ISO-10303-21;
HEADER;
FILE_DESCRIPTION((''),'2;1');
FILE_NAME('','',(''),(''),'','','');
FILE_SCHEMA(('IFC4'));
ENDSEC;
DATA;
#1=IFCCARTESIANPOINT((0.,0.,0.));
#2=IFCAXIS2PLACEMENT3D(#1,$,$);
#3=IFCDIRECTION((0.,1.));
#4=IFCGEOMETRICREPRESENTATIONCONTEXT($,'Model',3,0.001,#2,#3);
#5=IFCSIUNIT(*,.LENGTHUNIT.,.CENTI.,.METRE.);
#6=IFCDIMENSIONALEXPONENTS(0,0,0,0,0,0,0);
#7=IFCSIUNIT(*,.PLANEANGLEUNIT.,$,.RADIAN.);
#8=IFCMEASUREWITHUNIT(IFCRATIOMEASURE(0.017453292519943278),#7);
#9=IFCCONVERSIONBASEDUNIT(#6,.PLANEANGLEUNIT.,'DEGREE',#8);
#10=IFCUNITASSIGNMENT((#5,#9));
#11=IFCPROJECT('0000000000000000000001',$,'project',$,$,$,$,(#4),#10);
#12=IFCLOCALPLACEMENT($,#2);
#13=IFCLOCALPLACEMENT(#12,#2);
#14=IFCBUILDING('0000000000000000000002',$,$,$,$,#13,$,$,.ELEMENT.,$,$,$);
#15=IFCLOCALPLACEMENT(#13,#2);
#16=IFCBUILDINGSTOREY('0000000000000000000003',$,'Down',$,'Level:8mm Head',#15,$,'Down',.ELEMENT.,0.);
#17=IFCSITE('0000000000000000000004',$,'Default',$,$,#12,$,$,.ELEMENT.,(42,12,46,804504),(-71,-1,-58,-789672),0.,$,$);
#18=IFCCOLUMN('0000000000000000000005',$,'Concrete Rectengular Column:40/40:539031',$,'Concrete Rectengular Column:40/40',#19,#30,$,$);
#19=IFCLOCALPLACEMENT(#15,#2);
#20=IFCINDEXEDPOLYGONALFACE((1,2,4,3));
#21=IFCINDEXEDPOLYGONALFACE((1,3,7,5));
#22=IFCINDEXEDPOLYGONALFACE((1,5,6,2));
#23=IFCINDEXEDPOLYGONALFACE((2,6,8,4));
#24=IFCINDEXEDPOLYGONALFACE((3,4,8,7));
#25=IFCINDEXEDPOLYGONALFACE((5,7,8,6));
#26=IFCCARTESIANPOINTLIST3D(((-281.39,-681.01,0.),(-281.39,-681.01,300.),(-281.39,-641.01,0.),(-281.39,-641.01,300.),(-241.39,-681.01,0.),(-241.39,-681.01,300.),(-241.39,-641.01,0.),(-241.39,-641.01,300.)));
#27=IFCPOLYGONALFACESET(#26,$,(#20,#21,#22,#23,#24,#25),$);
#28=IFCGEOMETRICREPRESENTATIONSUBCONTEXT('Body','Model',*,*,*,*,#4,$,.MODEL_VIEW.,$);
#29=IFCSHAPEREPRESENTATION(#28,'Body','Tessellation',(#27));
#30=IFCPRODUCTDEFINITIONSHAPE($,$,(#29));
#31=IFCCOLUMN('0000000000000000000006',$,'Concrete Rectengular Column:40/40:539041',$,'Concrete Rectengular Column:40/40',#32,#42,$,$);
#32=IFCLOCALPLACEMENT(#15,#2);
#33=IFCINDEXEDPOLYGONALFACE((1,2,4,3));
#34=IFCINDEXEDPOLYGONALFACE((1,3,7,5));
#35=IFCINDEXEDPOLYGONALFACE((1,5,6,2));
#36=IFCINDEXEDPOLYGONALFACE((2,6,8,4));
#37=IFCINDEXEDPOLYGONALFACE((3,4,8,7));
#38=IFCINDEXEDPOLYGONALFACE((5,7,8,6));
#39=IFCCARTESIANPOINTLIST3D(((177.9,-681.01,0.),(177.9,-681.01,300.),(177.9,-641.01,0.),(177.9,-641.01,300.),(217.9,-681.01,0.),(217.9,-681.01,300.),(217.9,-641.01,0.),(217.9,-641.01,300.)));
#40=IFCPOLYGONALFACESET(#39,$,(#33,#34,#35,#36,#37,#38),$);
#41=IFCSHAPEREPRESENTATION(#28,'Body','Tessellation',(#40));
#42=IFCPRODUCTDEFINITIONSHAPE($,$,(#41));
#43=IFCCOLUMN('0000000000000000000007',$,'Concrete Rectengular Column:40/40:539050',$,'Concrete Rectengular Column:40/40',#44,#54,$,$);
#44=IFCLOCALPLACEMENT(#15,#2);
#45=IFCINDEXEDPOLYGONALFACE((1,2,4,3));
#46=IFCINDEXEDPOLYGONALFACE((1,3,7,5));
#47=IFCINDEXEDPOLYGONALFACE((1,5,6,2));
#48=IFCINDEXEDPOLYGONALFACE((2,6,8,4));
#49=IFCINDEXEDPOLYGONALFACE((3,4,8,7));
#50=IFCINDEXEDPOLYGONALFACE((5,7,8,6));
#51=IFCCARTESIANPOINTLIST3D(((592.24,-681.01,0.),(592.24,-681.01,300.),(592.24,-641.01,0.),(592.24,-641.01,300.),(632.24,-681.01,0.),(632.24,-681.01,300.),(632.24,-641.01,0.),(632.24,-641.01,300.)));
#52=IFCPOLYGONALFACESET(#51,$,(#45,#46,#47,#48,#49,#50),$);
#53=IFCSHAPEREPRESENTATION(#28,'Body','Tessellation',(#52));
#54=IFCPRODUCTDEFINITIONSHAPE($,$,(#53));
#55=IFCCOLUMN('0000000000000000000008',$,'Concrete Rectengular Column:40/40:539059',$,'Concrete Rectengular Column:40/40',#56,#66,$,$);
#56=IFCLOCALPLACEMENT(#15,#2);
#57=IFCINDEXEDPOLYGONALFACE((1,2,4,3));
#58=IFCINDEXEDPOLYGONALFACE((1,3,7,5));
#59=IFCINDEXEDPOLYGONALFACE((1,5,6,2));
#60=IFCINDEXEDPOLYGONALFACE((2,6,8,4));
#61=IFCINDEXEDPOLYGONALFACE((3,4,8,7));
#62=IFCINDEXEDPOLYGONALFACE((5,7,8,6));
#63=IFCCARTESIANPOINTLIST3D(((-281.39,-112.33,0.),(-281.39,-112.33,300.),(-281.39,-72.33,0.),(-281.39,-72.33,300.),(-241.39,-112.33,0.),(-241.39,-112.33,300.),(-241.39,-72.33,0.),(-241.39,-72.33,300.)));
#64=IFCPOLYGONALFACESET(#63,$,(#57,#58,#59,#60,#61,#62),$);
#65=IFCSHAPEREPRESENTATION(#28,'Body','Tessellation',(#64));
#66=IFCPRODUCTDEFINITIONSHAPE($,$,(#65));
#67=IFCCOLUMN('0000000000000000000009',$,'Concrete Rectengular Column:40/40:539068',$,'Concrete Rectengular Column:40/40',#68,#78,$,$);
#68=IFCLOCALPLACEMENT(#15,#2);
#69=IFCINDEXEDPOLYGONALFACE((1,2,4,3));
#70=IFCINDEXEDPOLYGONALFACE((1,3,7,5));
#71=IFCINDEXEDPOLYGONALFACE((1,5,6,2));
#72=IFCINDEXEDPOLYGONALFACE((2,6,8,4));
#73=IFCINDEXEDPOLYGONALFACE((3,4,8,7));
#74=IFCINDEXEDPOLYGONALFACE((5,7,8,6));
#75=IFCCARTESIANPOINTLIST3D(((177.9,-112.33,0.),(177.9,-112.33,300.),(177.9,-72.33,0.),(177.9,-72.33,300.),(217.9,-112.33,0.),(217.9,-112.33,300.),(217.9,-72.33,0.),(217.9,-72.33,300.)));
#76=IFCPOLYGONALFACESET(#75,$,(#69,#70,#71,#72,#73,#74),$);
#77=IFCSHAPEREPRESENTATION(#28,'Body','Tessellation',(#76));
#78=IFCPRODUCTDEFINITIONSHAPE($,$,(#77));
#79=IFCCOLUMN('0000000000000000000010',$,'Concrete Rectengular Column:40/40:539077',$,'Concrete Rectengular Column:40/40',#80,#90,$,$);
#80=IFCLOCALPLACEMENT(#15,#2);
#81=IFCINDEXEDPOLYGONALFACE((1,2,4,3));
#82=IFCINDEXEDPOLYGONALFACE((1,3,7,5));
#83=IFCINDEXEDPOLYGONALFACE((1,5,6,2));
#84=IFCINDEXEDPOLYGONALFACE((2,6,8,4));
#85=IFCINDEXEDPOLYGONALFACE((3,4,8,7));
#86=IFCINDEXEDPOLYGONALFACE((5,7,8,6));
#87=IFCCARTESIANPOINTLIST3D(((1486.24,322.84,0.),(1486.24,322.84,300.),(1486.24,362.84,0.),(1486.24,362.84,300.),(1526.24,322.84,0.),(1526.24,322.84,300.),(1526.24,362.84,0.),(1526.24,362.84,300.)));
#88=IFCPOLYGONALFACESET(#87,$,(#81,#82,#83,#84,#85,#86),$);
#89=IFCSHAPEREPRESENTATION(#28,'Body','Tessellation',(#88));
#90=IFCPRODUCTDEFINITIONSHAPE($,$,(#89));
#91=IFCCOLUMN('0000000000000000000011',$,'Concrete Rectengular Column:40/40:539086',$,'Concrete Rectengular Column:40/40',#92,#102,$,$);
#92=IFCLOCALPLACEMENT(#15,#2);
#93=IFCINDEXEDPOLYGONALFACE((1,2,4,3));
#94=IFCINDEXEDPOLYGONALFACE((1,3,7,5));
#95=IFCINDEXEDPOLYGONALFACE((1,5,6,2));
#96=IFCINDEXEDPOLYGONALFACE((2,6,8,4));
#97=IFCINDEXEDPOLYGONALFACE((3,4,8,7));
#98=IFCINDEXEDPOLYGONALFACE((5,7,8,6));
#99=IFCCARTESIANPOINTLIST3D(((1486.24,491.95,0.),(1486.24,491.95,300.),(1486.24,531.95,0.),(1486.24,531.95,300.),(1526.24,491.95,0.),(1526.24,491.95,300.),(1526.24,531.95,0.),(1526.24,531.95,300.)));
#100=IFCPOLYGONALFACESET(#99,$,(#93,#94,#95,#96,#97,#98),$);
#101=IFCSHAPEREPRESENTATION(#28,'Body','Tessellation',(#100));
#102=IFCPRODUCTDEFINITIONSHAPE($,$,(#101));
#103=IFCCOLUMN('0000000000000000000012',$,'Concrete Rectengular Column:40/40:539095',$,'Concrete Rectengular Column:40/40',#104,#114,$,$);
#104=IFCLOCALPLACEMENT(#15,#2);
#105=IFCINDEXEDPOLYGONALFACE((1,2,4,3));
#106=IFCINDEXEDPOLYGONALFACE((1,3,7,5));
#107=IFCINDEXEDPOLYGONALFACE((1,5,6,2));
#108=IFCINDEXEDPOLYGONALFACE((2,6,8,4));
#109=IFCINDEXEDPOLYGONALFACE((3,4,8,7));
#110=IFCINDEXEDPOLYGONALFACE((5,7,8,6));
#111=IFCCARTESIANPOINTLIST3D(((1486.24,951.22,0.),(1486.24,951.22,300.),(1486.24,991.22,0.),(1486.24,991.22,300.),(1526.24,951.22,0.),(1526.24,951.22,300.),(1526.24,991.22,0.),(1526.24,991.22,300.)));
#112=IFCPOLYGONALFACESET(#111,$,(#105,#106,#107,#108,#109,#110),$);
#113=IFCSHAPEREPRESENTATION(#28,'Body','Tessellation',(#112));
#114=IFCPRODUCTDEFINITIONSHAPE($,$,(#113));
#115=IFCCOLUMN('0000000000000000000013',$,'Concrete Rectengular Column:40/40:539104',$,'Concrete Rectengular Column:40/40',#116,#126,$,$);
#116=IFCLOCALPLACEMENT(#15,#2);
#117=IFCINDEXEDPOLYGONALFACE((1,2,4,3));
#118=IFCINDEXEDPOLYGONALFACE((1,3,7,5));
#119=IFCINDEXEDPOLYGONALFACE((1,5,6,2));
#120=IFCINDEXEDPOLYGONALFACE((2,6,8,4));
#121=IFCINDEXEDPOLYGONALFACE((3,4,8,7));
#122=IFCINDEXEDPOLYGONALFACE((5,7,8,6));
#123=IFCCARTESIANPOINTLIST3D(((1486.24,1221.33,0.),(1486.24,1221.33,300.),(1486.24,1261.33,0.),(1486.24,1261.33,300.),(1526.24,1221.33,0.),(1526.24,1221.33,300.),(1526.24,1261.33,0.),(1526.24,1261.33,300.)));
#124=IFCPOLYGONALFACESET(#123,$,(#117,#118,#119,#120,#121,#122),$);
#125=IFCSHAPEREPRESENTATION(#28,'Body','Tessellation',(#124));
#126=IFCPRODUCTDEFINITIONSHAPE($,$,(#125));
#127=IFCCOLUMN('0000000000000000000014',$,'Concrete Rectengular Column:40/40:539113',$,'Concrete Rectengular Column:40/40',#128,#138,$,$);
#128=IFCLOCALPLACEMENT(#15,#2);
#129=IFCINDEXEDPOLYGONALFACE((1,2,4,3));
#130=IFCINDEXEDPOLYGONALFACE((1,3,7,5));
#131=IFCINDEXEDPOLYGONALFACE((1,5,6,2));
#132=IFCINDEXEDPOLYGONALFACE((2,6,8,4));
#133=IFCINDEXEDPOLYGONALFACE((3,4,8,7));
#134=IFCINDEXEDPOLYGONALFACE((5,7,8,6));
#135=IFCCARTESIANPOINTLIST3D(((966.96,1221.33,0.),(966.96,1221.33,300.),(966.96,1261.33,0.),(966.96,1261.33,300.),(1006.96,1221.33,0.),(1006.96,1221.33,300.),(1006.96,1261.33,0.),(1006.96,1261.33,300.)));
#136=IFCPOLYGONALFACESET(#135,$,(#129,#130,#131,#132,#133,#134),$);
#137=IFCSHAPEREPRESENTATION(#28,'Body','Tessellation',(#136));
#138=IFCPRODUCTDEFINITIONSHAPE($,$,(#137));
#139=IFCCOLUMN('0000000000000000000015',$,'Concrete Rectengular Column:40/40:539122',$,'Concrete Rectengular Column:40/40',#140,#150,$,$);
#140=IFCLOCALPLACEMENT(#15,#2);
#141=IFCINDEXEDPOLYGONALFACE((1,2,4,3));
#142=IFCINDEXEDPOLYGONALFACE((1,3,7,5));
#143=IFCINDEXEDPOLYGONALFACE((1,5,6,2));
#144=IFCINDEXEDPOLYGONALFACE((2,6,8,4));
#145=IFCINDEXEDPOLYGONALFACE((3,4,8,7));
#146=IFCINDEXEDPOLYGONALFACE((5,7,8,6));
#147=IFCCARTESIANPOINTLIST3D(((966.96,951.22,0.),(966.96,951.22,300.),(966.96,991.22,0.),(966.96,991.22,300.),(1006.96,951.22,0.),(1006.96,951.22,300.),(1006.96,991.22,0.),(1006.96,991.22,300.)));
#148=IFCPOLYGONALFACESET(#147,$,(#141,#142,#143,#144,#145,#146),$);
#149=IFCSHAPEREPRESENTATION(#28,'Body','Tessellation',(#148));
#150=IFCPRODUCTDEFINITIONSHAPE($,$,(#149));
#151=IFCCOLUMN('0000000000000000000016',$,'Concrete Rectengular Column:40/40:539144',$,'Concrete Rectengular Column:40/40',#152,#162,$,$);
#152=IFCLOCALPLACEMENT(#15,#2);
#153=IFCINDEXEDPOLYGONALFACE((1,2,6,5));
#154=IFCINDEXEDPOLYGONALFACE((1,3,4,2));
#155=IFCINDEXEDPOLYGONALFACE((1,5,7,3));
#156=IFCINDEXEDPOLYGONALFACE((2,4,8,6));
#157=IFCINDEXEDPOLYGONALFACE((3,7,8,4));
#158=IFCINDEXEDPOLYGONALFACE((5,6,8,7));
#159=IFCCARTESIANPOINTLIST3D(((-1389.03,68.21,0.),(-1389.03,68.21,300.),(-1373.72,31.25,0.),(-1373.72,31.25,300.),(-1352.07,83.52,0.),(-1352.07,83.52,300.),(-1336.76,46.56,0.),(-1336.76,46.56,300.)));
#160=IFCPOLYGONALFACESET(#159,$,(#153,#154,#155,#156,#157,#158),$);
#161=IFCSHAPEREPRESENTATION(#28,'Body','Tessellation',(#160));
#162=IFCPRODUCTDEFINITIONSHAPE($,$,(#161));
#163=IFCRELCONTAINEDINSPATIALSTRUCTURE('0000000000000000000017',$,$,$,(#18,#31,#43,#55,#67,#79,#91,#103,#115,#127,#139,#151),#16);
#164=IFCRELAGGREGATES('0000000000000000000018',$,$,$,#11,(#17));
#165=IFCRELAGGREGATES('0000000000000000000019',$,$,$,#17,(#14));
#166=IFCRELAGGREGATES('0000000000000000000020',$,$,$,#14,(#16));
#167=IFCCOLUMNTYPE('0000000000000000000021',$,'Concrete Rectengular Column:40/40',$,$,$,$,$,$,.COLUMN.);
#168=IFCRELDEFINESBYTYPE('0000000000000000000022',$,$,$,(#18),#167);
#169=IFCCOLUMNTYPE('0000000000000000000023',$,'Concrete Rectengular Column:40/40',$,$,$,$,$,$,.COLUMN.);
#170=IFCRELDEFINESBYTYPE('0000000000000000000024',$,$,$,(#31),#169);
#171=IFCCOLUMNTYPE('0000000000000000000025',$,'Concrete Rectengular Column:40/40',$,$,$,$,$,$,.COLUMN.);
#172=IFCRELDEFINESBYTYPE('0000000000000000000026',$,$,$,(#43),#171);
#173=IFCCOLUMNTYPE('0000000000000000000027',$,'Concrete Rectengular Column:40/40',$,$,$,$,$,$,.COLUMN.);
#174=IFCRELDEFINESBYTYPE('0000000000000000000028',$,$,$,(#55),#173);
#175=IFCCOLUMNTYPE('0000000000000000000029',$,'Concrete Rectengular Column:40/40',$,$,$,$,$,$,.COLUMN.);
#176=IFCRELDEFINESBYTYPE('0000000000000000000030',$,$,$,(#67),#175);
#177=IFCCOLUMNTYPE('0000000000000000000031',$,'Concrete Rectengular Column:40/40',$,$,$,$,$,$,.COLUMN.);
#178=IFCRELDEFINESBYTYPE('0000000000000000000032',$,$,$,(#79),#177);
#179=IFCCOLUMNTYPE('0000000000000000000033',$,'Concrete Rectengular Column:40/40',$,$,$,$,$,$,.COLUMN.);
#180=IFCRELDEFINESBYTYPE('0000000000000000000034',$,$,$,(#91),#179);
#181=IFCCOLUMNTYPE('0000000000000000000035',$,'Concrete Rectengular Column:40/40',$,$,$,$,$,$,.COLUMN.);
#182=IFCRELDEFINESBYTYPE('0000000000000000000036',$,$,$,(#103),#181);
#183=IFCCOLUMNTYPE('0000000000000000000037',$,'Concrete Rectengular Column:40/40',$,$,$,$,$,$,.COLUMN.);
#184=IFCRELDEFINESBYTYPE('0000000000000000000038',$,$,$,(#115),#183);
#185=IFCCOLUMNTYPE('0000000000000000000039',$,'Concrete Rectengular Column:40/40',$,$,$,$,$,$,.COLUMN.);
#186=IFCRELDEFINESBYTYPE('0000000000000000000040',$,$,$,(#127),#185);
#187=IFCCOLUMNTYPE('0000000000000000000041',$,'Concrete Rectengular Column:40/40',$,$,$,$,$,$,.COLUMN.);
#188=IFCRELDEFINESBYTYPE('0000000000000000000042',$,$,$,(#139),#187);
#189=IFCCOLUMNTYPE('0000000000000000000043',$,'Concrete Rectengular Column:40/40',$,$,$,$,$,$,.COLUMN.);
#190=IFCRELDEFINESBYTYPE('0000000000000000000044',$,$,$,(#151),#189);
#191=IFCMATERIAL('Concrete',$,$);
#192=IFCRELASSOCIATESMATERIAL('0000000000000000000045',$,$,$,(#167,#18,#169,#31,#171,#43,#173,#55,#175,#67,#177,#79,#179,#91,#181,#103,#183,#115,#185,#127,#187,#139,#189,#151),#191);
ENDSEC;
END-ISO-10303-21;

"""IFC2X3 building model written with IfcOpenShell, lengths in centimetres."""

from ifc_helpers import new_model, entity, si_unit, converted_unit, direction, frame, frame_2d, origin, origin_2d_with_axis, place, context, subcontext, project, spatial, rectangle, extrude, source, transform, mapped, material, type_object, type_shapes, element, save


model = new_model("IFC2X3")

# Units and contexts
model_context = context("Model", 3, precision=0.001, world=origin(), true_north=direction((0.0, 1.0)))
body_context = subcontext(model_context, "Body", "Model", "MODEL_VIEW")
ifc_project = project(units=[si_unit("LENGTHUNIT", "METRE", prefix="CENTI"), converted_unit("PLANEANGLEUNIT", "DEGREE", entity("IfcRatioMeasure", 0.017453292519943278), si_unit("PLANEANGLEUNIT", "RADIAN"), dimensions=[0, 0, 0, 0, 0, 0, 0])], contexts=[model_context])

# Site, building, storey
site_placement = place(None, origin())
site = spatial("IfcSite", under=ifc_project, at=site_placement, Name="Default", CompositionType="ELEMENT", RefLatitude=(42, 12, 46, 804504), RefLongitude=(-71, -1, -58, -789672), RefElevation=0.0)
building_placement = place(site_placement, origin())
building = spatial("IfcBuilding", under=site, at=building_placement, CompositionType="ELEMENT")
storey_placement = place(building_placement, origin())
storey = spatial("IfcBuildingStorey", under=building, at=storey_placement, Name="Down", ObjectType="Level:8mm Head", LongName="Down", CompositionType="ELEMENT", Elevation=0.0)

# Columns
ifc_material = material(Name="Concrete")
column_type_1 = type_object("IfcColumnType", Name="Concrete Rectengular Column:40/40", PredefinedType="COLUMN", material=ifc_material)
shared_shape_1 = source(origin(), body_context, "Body", "SweptSolid", [
    extrude(rectangle(XDim=40.0, YDim=40.0, at=origin_2d_with_axis()), frame((-261.39, -661.01, 0.0), z_axis=(0.0, 0.0, 1.0), x_axis=(0.0, -1.0, 0.0)), (0.0, 0.0, 1.0), 300.0),
])
type_shapes(column_type_1, [shared_shape_1])
column_1_placement = place(storey_placement, origin())
element("IfcColumn", 1, at=column_1_placement, inside=storey, type_object=column_type_1, material=ifc_material, Name="Concrete Rectengular Column:40/40:539031", ObjectType="Concrete Rectengular Column:40/40", context=body_context, shape_type="MappedRepresentation", body=[
    mapped(shared_shape_1, transform((0.0, 0.0, 0.0), scale=1.0)),
])
column_type_2 = type_object("IfcColumnType", Name="Concrete Rectengular Column:40/40", PredefinedType="COLUMN", material=ifc_material)
shared_shape_2 = source(origin(), body_context, "Body", "SweptSolid", [
    extrude(rectangle(XDim=40.0, YDim=40.0, at=frame_2d((0.0, 0.0), x_axis=(1.0, 0.0))), frame((197.9, -661.01, 0.0), z_axis=(0.0, 0.0, 1.0), x_axis=(0.0, -1.0, 0.0)), (0.0, 0.0, 1.0), 300.0),
])
type_shapes(column_type_2, [shared_shape_2])
column_2_placement = place(storey_placement, origin())
element("IfcColumn", 2, at=column_2_placement, inside=storey, type_object=column_type_2, material=ifc_material, Name="Concrete Rectengular Column:40/40:539041", ObjectType="Concrete Rectengular Column:40/40", context=body_context, shape_type="MappedRepresentation", body=[
    mapped(shared_shape_2, transform((0.0, 0.0, 0.0), scale=1.0)),
])
column_type_3 = type_object("IfcColumnType", Name="Concrete Rectengular Column:40/40", PredefinedType="COLUMN", material=ifc_material)
shared_shape_3 = source(origin(), body_context, "Body", "SweptSolid", [
    extrude(rectangle(XDim=40.0, YDim=40.0, at=origin_2d_with_axis()), frame((612.24, -661.01, 0.0), z_axis=(0.0, 0.0, 1.0), x_axis=(0.0, -1.0, 0.0)), (0.0, 0.0, 1.0), 300.0),
])
type_shapes(column_type_3, [shared_shape_3])
column_3_placement = place(storey_placement, origin())
element("IfcColumn", 3, at=column_3_placement, inside=storey, type_object=column_type_3, material=ifc_material, Name="Concrete Rectengular Column:40/40:539050", ObjectType="Concrete Rectengular Column:40/40", context=body_context, shape_type="MappedRepresentation", body=[
    mapped(shared_shape_3, transform((0.0, 0.0, 0.0), scale=1.0)),
])
column_type_4 = type_object("IfcColumnType", Name="Concrete Rectengular Column:40/40", PredefinedType="COLUMN", material=ifc_material)
shared_shape_4 = source(origin(), body_context, "Body", "SweptSolid", [
    extrude(rectangle(XDim=40.0, YDim=40.0, at=origin_2d_with_axis()), frame((-261.39, -92.33, 0.0), z_axis=(0.0, 0.0, 1.0), x_axis=(0.0, -1.0, 0.0)), (0.0, 0.0, 1.0), 300.0),
])
type_shapes(column_type_4, [shared_shape_4])
column_4_placement = place(storey_placement, origin())
element("IfcColumn", 4, at=column_4_placement, inside=storey, type_object=column_type_4, material=ifc_material, Name="Concrete Rectengular Column:40/40:539059", ObjectType="Concrete Rectengular Column:40/40", context=body_context, shape_type="MappedRepresentation", body=[
    mapped(shared_shape_4, transform((0.0, 0.0, 0.0), scale=1.0)),
])
column_type_5 = type_object("IfcColumnType", Name="Concrete Rectengular Column:40/40", PredefinedType="COLUMN", material=ifc_material)
shared_shape_5 = source(origin(), body_context, "Body", "SweptSolid", [
    extrude(rectangle(XDim=40.0, YDim=40.0, at=frame_2d((0.0, 0.0), x_axis=(1.0, 0.0))), frame((197.9, -92.33, 0.0), z_axis=(0.0, 0.0, 1.0), x_axis=(0.0, -1.0, 0.0)), (0.0, 0.0, 1.0), 300.0),
])
type_shapes(column_type_5, [shared_shape_5])
column_5_placement = place(storey_placement, origin())
element("IfcColumn", 5, at=column_5_placement, inside=storey, type_object=column_type_5, material=ifc_material, Name="Concrete Rectengular Column:40/40:539068", ObjectType="Concrete Rectengular Column:40/40", context=body_context, shape_type="MappedRepresentation", body=[
    mapped(shared_shape_5, transform((0.0, 0.0, 0.0), scale=1.0)),
])
column_type_6 = type_object("IfcColumnType", Name="Concrete Rectengular Column:40/40", PredefinedType="COLUMN", material=ifc_material)
shared_shape_6 = source(origin(), body_context, "Body", "SweptSolid", [
    extrude(rectangle(XDim=40.0, YDim=40.0, at=origin_2d_with_axis()), frame((1506.24, 342.84, 0.0), z_axis=(0.0, 0.0, 1.0), x_axis=(0.0, -1.0, 0.0)), (0.0, 0.0, 1.0), 300.0),
])
type_shapes(column_type_6, [shared_shape_6])
column_6_placement = place(storey_placement, origin())
element("IfcColumn", 6, at=column_6_placement, inside=storey, type_object=column_type_6, material=ifc_material, Name="Concrete Rectengular Column:40/40:539077", ObjectType="Concrete Rectengular Column:40/40", context=body_context, shape_type="MappedRepresentation", body=[
    mapped(shared_shape_6, transform((0.0, 0.0, 0.0), scale=1.0)),
])
column_type_7 = type_object("IfcColumnType", Name="Concrete Rectengular Column:40/40", PredefinedType="COLUMN", material=ifc_material)
shared_shape_7 = source(origin(), body_context, "Body", "SweptSolid", [
    extrude(rectangle(XDim=40.0, YDim=40.0, at=origin_2d_with_axis()), frame((1506.24, 511.95, 0.0), z_axis=(0.0, 0.0, 1.0), x_axis=(0.0, -1.0, 0.0)), (0.0, 0.0, 1.0), 300.0),
])
type_shapes(column_type_7, [shared_shape_7])
column_7_placement = place(storey_placement, origin())
element("IfcColumn", 7, at=column_7_placement, inside=storey, type_object=column_type_7, material=ifc_material, Name="Concrete Rectengular Column:40/40:539086", ObjectType="Concrete Rectengular Column:40/40", context=body_context, shape_type="MappedRepresentation", body=[
    mapped(shared_shape_7, transform((0.0, 0.0, 0.0), scale=1.0)),
])
column_type_8 = type_object("IfcColumnType", Name="Concrete Rectengular Column:40/40", PredefinedType="COLUMN", material=ifc_material)
shared_shape_8 = source(origin(), body_context, "Body", "SweptSolid", [
    extrude(rectangle(XDim=40.0, YDim=40.0, at=origin_2d_with_axis()), frame((1506.24, 971.22, 0.0), z_axis=(0.0, 0.0, 1.0), x_axis=(0.0, -1.0, 0.0)), (0.0, 0.0, 1.0), 300.0),
])
type_shapes(column_type_8, [shared_shape_8])
column_8_placement = place(storey_placement, origin())
element("IfcColumn", 8, at=column_8_placement, inside=storey, type_object=column_type_8, material=ifc_material, Name="Concrete Rectengular Column:40/40:539095", ObjectType="Concrete Rectengular Column:40/40", context=body_context, shape_type="MappedRepresentation", body=[
    mapped(shared_shape_8, transform((0.0, 0.0, 0.0), scale=1.0)),
])
column_type_9 = type_object("IfcColumnType", Name="Concrete Rectengular Column:40/40", PredefinedType="COLUMN", material=ifc_material)
shared_shape_9 = source(origin(), body_context, "Body", "SweptSolid", [
    extrude(rectangle(XDim=40.0, YDim=40.0, at=origin_2d_with_axis()), frame((1506.24, 1241.33, 0.0), z_axis=(0.0, 0.0, 1.0), x_axis=(0.0, -1.0, 0.0)), (0.0, 0.0, 1.0), 300.0),
])
type_shapes(column_type_9, [shared_shape_9])
column_9_placement = place(storey_placement, origin())
element("IfcColumn", 9, at=column_9_placement, inside=storey, type_object=column_type_9, material=ifc_material, Name="Concrete Rectengular Column:40/40:539104", ObjectType="Concrete Rectengular Column:40/40", context=body_context, shape_type="MappedRepresentation", body=[
    mapped(shared_shape_9, transform((0.0, 0.0, 0.0), scale=1.0)),
])
column_type_10 = type_object("IfcColumnType", Name="Concrete Rectengular Column:40/40", PredefinedType="COLUMN", material=ifc_material)
shared_shape_10 = source(origin(), body_context, "Body", "SweptSolid", [
    extrude(rectangle(XDim=40.0, YDim=40.0, at=origin_2d_with_axis()), frame((986.96, 1241.33, 0.0), z_axis=(0.0, 0.0, 1.0), x_axis=(0.0, -1.0, 0.0)), (0.0, 0.0, 1.0), 300.0),
])
type_shapes(column_type_10, [shared_shape_10])
column_10_placement = place(storey_placement, origin())
element("IfcColumn", 10, at=column_10_placement, inside=storey, type_object=column_type_10, material=ifc_material, Name="Concrete Rectengular Column:40/40:539113", ObjectType="Concrete Rectengular Column:40/40", context=body_context, shape_type="MappedRepresentation", body=[
    mapped(shared_shape_10, transform((0.0, 0.0, 0.0), scale=1.0)),
])
column_type_11 = type_object("IfcColumnType", Name="Concrete Rectengular Column:40/40", PredefinedType="COLUMN", material=ifc_material)
shared_shape_11 = source(origin(), body_context, "Body", "SweptSolid", [
    extrude(rectangle(XDim=40.0, YDim=40.0, at=origin_2d_with_axis()), frame((986.96, 971.22, 0.0), z_axis=(0.0, 0.0, 1.0), x_axis=(0.0, -1.0, 0.0)), (0.0, 0.0, 1.0), 300.0),
])
type_shapes(column_type_11, [shared_shape_11])
column_11_placement = place(storey_placement, origin())
element("IfcColumn", 11, at=column_11_placement, inside=storey, type_object=column_type_11, material=ifc_material, Name="Concrete Rectengular Column:40/40:539122", ObjectType="Concrete Rectengular Column:40/40", context=body_context, shape_type="MappedRepresentation", body=[
    mapped(shared_shape_11, transform((0.0, 0.0, 0.0), scale=1.0)),
])
column_type_12 = type_object("IfcColumnType", Name="Concrete Rectengular Column:40/40", PredefinedType="COLUMN", material=ifc_material)
shared_shape_12 = source(origin(), body_context, "Body", "SweptSolid", [
    extrude(rectangle(XDim=40.0, YDim=40.0, at=origin_2d_with_axis()), frame((-1362.89, 57.39, 0.0), z_axis=(0.0, 0.0, 1.0), x_axis=(-0.382737, 0.923857, 0.0)), (0.0, 0.0, 1.0), 300.0),
])
type_shapes(column_type_12, [shared_shape_12])
column_12_placement = place(storey_placement, origin())
element("IfcColumn", 12, at=column_12_placement, inside=storey, type_object=column_type_12, material=ifc_material, Name="Concrete Rectengular Column:40/40:539144", ObjectType="Concrete Rectengular Column:40/40", context=body_context, shape_type="MappedRepresentation", body=[
    mapped(shared_shape_12, transform((0.0, 0.0, 0.0), scale=1.0)),
])

save(model, "model.ifc")
